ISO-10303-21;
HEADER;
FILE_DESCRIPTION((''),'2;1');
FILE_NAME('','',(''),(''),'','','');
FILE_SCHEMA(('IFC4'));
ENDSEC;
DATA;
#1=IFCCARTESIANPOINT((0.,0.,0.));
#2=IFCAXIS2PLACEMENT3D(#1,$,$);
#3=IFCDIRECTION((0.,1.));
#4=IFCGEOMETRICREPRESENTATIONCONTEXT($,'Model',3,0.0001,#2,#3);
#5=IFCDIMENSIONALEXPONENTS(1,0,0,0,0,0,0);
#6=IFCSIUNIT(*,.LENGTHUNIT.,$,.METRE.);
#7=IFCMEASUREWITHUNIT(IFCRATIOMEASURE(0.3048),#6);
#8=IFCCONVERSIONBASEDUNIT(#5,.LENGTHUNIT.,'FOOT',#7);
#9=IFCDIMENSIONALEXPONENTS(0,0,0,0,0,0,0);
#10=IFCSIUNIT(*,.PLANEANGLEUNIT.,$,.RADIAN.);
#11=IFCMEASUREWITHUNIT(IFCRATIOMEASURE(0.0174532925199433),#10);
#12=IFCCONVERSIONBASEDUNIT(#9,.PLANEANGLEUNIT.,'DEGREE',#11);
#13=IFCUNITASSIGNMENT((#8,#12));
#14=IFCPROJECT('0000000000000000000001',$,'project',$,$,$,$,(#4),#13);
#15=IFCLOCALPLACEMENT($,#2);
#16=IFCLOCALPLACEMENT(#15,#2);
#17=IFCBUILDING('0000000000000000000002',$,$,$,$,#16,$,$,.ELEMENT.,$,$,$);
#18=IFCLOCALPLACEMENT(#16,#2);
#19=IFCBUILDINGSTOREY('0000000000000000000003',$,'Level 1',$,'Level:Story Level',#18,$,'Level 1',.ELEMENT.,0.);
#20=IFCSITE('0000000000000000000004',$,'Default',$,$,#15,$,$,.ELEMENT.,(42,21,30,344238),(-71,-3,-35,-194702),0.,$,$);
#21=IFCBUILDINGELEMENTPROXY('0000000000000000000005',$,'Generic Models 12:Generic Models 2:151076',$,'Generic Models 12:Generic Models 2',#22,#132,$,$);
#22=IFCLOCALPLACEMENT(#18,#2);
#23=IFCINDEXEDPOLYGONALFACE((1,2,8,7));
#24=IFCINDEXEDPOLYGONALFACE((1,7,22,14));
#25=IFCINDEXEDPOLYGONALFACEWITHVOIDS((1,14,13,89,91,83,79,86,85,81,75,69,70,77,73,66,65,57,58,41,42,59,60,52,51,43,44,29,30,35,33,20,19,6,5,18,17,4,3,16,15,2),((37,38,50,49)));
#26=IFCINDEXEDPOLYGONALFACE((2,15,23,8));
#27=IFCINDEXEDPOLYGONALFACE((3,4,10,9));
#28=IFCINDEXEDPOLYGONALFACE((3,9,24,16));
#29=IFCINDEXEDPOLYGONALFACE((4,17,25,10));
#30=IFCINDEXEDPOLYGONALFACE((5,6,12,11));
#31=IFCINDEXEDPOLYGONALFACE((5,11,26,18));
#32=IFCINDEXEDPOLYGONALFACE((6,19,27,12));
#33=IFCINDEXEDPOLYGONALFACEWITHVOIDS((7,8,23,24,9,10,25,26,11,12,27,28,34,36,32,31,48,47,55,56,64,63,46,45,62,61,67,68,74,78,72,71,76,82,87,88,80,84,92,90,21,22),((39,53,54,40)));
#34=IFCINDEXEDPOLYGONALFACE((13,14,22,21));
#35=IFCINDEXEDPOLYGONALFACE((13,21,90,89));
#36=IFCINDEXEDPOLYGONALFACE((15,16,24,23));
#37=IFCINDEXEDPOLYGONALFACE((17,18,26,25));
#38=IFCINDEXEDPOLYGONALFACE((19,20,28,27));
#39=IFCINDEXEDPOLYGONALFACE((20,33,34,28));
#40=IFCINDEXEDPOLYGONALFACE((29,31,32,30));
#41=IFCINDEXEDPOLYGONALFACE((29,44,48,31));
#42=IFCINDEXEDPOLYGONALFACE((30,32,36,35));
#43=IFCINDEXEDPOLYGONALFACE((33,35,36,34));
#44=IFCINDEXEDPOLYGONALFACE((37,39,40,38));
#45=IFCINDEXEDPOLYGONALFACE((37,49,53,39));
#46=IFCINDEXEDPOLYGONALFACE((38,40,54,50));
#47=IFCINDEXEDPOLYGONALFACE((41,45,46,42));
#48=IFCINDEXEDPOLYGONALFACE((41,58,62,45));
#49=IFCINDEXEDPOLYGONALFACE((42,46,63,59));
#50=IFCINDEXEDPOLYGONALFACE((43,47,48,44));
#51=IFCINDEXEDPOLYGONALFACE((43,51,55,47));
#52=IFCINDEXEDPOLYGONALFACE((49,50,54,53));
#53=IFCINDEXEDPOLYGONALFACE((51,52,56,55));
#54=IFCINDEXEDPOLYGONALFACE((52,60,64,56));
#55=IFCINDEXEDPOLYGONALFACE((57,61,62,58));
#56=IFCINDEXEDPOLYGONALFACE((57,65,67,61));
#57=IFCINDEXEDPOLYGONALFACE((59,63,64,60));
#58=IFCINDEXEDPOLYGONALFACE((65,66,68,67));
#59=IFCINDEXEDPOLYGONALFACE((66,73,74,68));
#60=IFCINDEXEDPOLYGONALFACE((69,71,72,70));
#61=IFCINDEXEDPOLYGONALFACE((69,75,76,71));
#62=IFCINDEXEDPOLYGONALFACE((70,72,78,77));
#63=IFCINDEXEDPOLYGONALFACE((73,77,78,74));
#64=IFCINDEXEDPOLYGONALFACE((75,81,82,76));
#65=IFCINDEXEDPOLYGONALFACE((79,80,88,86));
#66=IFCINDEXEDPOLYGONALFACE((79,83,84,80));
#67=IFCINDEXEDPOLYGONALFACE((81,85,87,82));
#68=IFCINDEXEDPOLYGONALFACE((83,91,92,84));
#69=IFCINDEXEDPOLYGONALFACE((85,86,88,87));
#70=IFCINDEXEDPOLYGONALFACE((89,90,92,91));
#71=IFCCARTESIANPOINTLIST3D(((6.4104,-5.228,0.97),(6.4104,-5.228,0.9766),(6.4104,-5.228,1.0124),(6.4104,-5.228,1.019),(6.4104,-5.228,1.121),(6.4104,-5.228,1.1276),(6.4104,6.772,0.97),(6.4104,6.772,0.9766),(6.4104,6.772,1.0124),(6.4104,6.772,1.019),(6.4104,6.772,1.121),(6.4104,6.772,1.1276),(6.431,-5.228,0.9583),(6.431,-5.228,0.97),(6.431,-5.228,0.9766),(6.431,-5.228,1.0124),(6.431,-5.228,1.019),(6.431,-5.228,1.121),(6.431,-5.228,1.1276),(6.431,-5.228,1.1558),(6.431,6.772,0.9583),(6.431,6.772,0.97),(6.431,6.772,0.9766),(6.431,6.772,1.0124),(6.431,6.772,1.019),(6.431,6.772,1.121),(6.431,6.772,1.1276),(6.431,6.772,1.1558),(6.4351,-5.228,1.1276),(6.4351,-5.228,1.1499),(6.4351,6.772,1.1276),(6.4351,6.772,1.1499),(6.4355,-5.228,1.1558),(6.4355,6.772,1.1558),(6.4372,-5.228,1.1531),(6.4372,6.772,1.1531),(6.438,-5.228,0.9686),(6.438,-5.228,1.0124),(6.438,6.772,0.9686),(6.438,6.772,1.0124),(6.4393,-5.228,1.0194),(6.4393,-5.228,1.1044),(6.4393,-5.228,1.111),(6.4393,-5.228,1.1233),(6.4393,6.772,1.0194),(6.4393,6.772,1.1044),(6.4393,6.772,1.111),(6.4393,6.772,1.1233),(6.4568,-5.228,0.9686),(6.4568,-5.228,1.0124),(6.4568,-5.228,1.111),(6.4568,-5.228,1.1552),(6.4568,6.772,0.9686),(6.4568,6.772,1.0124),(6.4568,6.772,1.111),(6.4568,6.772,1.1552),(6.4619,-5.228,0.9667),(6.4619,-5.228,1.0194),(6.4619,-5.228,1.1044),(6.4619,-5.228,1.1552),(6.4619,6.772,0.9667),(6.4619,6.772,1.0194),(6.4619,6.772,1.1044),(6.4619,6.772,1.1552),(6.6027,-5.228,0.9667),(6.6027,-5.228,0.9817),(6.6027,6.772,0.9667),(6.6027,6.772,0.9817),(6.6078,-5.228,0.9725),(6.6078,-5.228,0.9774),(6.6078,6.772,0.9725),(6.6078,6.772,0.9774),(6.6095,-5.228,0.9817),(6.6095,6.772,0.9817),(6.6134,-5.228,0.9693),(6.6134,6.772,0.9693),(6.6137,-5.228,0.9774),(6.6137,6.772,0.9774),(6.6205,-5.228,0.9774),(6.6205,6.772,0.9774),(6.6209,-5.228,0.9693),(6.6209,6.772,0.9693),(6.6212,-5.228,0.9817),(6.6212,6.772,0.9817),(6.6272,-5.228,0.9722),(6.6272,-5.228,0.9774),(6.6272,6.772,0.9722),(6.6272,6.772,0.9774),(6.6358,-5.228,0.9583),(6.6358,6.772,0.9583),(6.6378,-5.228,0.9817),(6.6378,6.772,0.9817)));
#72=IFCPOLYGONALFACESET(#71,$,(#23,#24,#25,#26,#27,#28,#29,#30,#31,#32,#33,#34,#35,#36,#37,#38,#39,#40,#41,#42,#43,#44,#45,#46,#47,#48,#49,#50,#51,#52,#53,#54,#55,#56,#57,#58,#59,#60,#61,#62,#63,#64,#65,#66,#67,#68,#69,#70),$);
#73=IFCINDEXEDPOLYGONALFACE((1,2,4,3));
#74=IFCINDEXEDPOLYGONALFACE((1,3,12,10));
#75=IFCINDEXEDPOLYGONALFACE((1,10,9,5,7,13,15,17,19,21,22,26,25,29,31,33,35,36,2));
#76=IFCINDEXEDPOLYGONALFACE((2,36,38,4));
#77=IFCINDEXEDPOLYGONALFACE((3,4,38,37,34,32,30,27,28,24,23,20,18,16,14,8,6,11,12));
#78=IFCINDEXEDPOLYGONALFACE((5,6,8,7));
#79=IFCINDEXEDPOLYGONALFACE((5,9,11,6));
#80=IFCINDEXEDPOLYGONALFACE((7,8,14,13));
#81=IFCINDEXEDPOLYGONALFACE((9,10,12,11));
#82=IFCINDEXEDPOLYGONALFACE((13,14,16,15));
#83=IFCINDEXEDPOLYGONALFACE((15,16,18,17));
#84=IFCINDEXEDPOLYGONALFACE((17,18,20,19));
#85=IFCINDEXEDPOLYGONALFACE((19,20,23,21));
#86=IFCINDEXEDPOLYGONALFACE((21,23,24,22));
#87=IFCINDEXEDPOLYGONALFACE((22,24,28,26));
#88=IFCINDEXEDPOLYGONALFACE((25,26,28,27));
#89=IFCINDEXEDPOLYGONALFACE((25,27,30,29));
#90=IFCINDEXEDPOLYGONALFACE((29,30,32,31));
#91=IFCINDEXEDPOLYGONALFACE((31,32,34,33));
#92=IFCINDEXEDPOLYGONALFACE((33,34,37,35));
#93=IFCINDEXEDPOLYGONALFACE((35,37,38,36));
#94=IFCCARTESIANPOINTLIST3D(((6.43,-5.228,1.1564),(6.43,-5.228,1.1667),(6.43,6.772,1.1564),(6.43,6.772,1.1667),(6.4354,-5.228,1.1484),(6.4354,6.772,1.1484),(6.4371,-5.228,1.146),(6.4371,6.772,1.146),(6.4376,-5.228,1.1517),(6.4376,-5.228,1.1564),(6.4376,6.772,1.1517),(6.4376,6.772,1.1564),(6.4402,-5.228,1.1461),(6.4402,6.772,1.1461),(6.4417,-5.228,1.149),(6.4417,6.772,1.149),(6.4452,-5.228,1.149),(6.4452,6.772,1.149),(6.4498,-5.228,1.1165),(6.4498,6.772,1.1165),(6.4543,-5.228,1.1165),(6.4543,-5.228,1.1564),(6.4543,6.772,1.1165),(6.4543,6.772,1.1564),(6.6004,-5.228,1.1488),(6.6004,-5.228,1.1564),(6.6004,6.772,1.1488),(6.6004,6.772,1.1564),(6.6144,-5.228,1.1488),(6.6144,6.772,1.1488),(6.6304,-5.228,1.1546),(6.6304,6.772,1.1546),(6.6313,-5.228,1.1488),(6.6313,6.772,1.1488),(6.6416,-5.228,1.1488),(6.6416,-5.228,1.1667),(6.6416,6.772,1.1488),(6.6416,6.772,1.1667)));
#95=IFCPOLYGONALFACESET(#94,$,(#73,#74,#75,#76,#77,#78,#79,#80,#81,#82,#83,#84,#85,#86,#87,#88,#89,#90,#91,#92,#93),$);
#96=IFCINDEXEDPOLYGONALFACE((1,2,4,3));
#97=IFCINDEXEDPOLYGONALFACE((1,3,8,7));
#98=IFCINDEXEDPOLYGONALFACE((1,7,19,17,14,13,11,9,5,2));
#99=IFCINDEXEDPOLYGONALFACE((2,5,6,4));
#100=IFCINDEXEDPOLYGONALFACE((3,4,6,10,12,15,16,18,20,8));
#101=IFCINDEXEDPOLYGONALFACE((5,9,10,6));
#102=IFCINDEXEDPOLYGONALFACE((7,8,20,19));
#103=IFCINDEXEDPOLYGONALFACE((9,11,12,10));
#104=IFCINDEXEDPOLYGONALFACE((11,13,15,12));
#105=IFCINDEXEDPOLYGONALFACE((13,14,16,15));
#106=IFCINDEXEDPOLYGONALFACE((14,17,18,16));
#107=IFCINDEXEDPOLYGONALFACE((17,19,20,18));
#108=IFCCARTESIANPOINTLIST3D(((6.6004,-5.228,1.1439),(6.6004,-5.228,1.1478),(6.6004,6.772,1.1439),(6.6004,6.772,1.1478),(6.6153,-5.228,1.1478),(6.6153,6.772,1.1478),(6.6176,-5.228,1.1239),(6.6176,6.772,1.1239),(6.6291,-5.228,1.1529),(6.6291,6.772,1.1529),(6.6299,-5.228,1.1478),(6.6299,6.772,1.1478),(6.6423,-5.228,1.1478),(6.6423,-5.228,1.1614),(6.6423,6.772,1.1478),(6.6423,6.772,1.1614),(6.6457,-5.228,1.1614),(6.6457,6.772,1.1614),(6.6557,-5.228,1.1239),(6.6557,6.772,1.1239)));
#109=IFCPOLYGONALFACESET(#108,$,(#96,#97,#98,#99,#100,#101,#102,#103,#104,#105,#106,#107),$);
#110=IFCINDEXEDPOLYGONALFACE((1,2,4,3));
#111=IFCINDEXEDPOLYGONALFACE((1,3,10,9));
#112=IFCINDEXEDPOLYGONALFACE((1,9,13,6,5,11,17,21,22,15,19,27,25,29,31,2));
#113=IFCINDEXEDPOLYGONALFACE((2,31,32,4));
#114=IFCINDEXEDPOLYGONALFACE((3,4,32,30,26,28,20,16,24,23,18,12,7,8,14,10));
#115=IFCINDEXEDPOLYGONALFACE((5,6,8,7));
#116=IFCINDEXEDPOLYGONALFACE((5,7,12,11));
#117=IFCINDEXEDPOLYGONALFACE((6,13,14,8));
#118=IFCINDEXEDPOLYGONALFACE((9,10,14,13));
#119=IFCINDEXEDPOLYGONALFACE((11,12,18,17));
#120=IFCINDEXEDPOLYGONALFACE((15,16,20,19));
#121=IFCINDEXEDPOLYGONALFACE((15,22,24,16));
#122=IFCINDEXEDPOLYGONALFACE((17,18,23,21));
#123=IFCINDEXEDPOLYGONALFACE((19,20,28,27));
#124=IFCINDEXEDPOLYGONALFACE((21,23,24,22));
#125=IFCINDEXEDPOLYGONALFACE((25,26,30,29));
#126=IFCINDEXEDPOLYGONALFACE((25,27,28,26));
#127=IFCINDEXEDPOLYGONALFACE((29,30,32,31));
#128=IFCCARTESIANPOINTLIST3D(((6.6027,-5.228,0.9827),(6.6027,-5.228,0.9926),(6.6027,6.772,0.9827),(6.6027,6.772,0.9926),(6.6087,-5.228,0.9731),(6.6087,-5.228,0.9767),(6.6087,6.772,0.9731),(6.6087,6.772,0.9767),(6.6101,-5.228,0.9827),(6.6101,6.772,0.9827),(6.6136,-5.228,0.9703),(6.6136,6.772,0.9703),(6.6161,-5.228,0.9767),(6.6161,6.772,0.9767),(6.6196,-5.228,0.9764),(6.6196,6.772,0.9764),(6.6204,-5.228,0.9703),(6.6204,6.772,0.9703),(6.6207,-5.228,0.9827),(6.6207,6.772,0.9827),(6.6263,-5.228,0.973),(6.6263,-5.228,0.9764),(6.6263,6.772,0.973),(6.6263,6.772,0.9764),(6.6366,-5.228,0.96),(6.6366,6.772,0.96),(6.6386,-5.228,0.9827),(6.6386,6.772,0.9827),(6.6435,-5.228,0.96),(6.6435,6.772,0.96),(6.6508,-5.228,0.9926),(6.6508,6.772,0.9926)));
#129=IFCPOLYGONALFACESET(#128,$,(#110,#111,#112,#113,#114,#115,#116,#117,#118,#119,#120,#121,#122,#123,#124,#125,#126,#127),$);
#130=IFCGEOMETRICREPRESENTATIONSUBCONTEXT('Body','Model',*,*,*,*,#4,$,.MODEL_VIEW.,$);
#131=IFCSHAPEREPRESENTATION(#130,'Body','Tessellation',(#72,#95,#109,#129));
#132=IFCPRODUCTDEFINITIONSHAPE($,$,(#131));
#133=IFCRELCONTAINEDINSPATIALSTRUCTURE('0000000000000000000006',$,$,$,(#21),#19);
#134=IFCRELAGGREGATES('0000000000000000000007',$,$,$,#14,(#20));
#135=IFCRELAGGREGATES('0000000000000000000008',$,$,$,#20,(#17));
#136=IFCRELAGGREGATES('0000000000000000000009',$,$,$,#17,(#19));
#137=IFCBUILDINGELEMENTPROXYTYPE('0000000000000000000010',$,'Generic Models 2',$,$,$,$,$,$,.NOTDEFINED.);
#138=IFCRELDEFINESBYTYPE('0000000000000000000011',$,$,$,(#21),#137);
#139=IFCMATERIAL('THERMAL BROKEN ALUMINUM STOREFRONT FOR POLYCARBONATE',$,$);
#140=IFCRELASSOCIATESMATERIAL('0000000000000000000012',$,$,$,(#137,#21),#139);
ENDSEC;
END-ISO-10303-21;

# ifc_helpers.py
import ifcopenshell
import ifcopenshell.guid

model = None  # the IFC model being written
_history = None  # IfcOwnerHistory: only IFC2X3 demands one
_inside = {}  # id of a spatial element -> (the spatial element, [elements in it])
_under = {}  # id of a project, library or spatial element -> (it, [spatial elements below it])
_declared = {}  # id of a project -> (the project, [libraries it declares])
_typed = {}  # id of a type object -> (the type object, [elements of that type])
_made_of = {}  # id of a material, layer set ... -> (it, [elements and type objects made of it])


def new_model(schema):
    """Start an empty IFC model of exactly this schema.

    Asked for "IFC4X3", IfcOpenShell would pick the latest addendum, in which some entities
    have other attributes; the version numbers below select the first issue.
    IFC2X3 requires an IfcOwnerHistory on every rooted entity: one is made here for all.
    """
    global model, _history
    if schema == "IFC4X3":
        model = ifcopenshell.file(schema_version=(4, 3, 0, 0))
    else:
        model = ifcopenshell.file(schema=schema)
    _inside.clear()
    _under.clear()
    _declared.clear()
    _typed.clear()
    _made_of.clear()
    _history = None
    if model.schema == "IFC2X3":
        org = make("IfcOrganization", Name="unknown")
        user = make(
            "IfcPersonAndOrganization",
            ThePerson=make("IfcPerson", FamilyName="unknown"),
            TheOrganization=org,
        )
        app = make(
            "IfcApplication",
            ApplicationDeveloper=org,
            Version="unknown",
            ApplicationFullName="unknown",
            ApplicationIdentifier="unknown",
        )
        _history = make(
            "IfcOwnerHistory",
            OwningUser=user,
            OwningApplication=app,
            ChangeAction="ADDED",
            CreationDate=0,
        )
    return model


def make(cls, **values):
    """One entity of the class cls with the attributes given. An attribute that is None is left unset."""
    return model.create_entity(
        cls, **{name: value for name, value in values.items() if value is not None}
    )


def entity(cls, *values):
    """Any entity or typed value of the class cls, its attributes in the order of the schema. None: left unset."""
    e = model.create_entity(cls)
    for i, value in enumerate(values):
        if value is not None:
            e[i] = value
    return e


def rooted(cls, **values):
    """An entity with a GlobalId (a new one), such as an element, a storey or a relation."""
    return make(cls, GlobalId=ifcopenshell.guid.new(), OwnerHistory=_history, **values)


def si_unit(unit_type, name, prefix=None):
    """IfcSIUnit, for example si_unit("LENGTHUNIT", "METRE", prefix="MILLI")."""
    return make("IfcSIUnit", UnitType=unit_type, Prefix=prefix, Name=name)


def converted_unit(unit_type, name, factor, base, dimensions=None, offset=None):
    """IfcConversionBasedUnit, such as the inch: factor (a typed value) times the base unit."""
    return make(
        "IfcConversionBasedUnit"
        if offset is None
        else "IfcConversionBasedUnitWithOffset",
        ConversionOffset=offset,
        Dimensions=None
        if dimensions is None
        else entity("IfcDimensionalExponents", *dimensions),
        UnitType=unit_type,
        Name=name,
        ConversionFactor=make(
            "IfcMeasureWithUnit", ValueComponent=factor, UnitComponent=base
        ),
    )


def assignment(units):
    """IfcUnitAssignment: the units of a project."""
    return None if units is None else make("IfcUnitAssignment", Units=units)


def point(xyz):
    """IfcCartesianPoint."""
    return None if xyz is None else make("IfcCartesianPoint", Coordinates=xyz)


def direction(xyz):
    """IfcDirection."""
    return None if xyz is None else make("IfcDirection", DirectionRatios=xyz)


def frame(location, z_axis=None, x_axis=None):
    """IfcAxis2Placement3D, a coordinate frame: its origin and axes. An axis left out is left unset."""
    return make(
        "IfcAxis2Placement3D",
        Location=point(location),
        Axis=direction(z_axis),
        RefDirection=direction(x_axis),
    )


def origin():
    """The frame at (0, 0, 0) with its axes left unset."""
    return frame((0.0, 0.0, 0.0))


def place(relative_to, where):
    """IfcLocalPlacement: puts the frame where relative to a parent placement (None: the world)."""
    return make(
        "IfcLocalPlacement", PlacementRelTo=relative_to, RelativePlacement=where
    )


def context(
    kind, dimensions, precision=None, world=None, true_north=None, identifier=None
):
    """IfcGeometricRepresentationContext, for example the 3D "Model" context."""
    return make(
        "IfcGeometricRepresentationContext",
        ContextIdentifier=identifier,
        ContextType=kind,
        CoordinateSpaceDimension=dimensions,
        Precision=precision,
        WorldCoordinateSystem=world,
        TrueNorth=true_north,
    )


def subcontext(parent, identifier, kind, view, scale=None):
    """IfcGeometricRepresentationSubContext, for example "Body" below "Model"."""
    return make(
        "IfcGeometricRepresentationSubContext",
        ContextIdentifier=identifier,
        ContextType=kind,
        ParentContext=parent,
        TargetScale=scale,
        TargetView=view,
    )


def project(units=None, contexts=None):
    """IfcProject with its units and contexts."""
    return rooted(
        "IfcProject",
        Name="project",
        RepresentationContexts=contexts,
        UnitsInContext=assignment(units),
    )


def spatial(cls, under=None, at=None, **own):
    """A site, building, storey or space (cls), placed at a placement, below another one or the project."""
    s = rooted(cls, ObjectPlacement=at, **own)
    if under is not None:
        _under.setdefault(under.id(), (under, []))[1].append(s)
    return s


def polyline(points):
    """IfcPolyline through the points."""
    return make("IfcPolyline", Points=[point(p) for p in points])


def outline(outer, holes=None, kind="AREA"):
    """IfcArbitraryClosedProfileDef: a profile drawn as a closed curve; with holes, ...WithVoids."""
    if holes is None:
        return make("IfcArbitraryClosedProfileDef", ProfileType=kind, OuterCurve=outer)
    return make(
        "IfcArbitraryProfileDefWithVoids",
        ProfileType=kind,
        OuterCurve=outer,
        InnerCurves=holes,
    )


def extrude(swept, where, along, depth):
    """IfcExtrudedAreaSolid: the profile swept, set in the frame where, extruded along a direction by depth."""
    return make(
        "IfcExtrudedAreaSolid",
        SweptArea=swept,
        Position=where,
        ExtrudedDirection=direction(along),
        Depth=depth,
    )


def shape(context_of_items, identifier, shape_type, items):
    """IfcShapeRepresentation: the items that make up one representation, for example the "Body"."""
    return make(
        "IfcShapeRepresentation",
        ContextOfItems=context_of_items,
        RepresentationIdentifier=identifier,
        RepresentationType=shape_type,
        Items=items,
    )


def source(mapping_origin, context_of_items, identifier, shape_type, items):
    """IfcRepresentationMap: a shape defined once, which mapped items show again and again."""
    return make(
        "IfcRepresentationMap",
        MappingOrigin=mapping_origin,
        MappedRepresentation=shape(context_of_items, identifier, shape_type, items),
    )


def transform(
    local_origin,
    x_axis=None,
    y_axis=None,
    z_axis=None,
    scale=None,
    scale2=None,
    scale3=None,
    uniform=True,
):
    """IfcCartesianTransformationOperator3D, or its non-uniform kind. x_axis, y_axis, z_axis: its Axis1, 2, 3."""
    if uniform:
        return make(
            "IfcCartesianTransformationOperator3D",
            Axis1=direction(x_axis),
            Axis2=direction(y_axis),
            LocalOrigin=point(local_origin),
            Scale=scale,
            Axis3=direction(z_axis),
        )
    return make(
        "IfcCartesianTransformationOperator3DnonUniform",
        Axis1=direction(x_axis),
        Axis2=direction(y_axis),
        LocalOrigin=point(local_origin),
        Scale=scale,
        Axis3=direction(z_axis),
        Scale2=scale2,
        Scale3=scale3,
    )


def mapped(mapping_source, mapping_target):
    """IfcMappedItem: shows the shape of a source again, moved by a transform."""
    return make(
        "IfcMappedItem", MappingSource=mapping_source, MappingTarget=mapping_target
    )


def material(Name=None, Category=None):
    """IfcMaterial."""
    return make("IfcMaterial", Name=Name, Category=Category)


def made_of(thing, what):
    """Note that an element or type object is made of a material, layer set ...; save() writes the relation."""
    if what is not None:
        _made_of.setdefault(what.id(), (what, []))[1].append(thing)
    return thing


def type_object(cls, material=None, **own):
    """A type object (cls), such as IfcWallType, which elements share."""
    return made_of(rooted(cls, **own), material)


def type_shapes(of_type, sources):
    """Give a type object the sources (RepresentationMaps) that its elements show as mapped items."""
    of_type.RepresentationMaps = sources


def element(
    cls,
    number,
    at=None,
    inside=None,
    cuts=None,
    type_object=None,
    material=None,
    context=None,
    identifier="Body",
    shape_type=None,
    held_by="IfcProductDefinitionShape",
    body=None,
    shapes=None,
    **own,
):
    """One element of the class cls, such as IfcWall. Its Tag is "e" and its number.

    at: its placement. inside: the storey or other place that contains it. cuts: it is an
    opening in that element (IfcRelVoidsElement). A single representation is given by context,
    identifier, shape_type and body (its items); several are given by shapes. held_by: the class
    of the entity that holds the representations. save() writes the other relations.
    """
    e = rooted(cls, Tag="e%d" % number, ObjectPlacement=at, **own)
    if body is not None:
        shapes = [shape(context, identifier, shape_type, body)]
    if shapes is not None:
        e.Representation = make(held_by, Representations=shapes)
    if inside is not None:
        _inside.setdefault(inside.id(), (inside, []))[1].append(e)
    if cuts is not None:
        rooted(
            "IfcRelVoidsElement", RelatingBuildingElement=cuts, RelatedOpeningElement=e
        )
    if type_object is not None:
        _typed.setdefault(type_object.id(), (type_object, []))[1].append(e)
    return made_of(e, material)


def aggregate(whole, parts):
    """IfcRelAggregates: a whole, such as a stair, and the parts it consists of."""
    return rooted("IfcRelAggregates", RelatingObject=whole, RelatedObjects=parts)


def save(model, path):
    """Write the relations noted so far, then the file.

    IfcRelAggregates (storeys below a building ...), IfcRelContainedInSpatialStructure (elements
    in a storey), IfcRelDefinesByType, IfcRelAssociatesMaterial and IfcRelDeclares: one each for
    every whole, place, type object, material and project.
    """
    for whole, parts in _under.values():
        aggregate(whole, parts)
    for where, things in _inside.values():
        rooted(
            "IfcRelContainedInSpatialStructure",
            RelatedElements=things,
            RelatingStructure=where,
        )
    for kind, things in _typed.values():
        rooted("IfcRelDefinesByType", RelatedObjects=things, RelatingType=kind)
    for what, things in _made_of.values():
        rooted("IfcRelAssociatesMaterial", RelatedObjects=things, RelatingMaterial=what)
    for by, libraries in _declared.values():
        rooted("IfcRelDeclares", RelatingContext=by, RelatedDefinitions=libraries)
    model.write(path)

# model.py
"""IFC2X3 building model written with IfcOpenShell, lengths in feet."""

from ifc_helpers import new_model, entity, si_unit, converted_unit, direction, frame, origin, place, context, subcontext, project, spatial, polyline, outline, extrude, source, transform, mapped, material, type_object, type_shapes, element, save


model = new_model("IFC2X3")

# Units and contexts
model_context = context("Model", 3, precision=0.0001, world=origin(), true_north=direction((0.0, 1.0)))
body_context = subcontext(model_context, "Body", "Model", "MODEL_VIEW")
ifc_project = project(units=[converted_unit("LENGTHUNIT", "FOOT", entity("IfcRatioMeasure", 0.3048), si_unit("LENGTHUNIT", "METRE"), dimensions=[1, 0, 0, 0, 0, 0, 0]), converted_unit("PLANEANGLEUNIT", "DEGREE", entity("IfcRatioMeasure", 0.0174532925199433), si_unit("PLANEANGLEUNIT", "RADIAN"), dimensions=[0, 0, 0, 0, 0, 0, 0])], contexts=[model_context])

# Site, building, storey
site_placement = place(None, origin())
site = spatial("IfcSite", under=ifc_project, at=site_placement, Name="Default", CompositionType="ELEMENT", RefLatitude=(42, 21, 30, 344238), RefLongitude=(-71, -3, -35, -194702), RefElevation=0.0)
building_placement = place(site_placement, origin())
building = spatial("IfcBuilding", under=site, at=building_placement, CompositionType="ELEMENT")
storey_placement = place(building_placement, origin())
storey = spatial("IfcBuildingStorey", under=building, at=storey_placement, Name="Level 1", ObjectType="Level:Story Level", LongName="Level 1", CompositionType="ELEMENT", Elevation=0.0)

# Building element proxy
ifc_material = material(Name="THERMAL BROKEN ALUMINUM STOREFRONT FOR POLYCARBONATE")
building_element_proxy_type_1 = type_object("IfcBuildingElementProxyType", Name="Generic Models 2", PredefinedType="NOTDEFINED", material=ifc_material)
shared_shape_1 = source(origin(), body_context, "Body", "SweptSolid", [
    extrude(outline(polyline([(-0.073, 0.107), (-0.058, 0.107), (-0.058, 0.1137), (-0.0623, 0.118), (-0.0623, 0.1121), (-0.0672, 0.1121), (-0.0704, 0.1177), (-0.0704, 0.1252), (-0.0675, 0.1315), (-0.0623, 0.1315), (-0.0623, 0.1248), (-0.058, 0.1255), (-0.058, 0.142), (-0.0814, 0.1401), (-0.0814, -0.0647), (-0.0697, -0.0647), (-0.0697, -0.0853), (-0.0631, -0.0853), (-0.0631, -0.0647), (-0.0273, -0.0647), (-0.0273, -0.0853), (-0.0207, -0.0853), (-0.0207, -0.0647), (0.0812, -0.0647), (0.0812, -0.0853), (0.0878, -0.0853), (0.0878, -0.0647), (0.1161, -0.0647), (0.1161, -0.0603), (0.1133, -0.0585), (0.1102, -0.0606), (0.0878, -0.0606), (0.0836, -0.0564), (0.0713, -0.0564), (0.0713, -0.0389), (0.1155, -0.0389), (0.1155, -0.0338), (0.0647, -0.0338), (0.0647, -0.0564), (-0.0203, -0.0564), (-0.0203, -0.0338), (-0.073, -0.0338), (-0.073, 0.107)]), holes=[polyline([(-0.0711, -0.0577), (-0.0711, -0.0389), (-0.0273, -0.0389), (-0.0273, -0.0577), (-0.0711, -0.0577)])]), frame((0.0, 0.2763, -0.2198), z_axis=(1.0, 0.0, 0.0), x_axis=(0.0, 0.0, 1.0)), (0.0, 0.0, 1.0), 12.0),
    extrude(outline(polyline([(0.068, 0.0006), (0.0711, 0.0006), (0.0726, 0.0031), (0.0702, 0.0064), (0.07, 0.011), (0.0776, 0.0114), (0.0771, 0.0217), (-0.1343, 0.0107), (-0.1334, -0.0072), (-0.1231, -0.0066), (-0.1224, -0.0008), (-0.1062, -0.0058), (-0.0922, -0.005), (-0.0926, 0.0025), (0.0533, 0.0101), (0.0554, -0.0297), (0.0599, -0.0295), (0.0628, 0.0032), (0.0663, 0.0034), (0.068, 0.0006)])), frame((0.0, 0.264, -0.1105), z_axis=(1.0, 0.0, 0.0), x_axis=(0.0, 0.998659, -0.051774)), (0.0, 0.0, 1.0), 12.0),
    extrude(outline(polyline([(-0.0104, -0.0212), (0.0284, -0.0212), (0.0186, 0.0156), (-0.0052, 0.0271), (-0.009, 0.026), (-0.0051, 0.0117), (-0.0065, -0.003), (-0.0014, -0.0025), (0.0018, -0.0144), (-0.0113, -0.0179), (-0.0104, -0.0212)])), frame((0.0, 0.1442, -0.1136), z_axis=(1.0, 0.0, 0.0), x_axis=(0.0, -0.257663, -0.966235)), (0.0, 0.0, 1.0), 12.0),
    extrude(outline(polyline([(-0.0218, -0.0251), (0.0116, -0.0251), (0.0131, -0.0183), (-0.0094, -0.0153), (-0.0056, 0.0021), (0.0008, 0.0018), (-0.0006, -0.0047), (0.0027, -0.0054), (0.0066, -0.0003), (0.0081, 0.0064), (0.0064, 0.0118), (0.0029, 0.0126), (0.0013, 0.0053), (-0.0032, 0.0125), (-0.0017, 0.0197), (-0.0114, 0.0218), (-0.0218, -0.0251)])), frame((0.0, 0.1504, -0.2827), z_axis=(1.0, 0.0, 0.0), x_axis=(0.0, 0.217466, -0.976068)), (0.0, 0.0, 1.0), 12.0),
])
type_shapes(building_element_proxy_type_1, [shared_shape_1])
proxy_1_placement = place(storey_placement, frame((6.772, -5.228, 1.2595), z_axis=(0.0, 0.0, 1.0), x_axis=(0.0, 1.0, 0.0)))
element("IfcBuildingElementProxy", 1, at=proxy_1_placement, inside=storey, type_object=building_element_proxy_type_1, material=ifc_material, Name="Generic Models 12:Generic Models 2:151076", ObjectType="Generic Models 12:Generic Models 2", context=body_context, shape_type="MappedRepresentation", body=[
    mapped(shared_shape_1, transform((0.0, 0.0, 0.0), scale=1.0)),
])

save(model, "model.ifc")
